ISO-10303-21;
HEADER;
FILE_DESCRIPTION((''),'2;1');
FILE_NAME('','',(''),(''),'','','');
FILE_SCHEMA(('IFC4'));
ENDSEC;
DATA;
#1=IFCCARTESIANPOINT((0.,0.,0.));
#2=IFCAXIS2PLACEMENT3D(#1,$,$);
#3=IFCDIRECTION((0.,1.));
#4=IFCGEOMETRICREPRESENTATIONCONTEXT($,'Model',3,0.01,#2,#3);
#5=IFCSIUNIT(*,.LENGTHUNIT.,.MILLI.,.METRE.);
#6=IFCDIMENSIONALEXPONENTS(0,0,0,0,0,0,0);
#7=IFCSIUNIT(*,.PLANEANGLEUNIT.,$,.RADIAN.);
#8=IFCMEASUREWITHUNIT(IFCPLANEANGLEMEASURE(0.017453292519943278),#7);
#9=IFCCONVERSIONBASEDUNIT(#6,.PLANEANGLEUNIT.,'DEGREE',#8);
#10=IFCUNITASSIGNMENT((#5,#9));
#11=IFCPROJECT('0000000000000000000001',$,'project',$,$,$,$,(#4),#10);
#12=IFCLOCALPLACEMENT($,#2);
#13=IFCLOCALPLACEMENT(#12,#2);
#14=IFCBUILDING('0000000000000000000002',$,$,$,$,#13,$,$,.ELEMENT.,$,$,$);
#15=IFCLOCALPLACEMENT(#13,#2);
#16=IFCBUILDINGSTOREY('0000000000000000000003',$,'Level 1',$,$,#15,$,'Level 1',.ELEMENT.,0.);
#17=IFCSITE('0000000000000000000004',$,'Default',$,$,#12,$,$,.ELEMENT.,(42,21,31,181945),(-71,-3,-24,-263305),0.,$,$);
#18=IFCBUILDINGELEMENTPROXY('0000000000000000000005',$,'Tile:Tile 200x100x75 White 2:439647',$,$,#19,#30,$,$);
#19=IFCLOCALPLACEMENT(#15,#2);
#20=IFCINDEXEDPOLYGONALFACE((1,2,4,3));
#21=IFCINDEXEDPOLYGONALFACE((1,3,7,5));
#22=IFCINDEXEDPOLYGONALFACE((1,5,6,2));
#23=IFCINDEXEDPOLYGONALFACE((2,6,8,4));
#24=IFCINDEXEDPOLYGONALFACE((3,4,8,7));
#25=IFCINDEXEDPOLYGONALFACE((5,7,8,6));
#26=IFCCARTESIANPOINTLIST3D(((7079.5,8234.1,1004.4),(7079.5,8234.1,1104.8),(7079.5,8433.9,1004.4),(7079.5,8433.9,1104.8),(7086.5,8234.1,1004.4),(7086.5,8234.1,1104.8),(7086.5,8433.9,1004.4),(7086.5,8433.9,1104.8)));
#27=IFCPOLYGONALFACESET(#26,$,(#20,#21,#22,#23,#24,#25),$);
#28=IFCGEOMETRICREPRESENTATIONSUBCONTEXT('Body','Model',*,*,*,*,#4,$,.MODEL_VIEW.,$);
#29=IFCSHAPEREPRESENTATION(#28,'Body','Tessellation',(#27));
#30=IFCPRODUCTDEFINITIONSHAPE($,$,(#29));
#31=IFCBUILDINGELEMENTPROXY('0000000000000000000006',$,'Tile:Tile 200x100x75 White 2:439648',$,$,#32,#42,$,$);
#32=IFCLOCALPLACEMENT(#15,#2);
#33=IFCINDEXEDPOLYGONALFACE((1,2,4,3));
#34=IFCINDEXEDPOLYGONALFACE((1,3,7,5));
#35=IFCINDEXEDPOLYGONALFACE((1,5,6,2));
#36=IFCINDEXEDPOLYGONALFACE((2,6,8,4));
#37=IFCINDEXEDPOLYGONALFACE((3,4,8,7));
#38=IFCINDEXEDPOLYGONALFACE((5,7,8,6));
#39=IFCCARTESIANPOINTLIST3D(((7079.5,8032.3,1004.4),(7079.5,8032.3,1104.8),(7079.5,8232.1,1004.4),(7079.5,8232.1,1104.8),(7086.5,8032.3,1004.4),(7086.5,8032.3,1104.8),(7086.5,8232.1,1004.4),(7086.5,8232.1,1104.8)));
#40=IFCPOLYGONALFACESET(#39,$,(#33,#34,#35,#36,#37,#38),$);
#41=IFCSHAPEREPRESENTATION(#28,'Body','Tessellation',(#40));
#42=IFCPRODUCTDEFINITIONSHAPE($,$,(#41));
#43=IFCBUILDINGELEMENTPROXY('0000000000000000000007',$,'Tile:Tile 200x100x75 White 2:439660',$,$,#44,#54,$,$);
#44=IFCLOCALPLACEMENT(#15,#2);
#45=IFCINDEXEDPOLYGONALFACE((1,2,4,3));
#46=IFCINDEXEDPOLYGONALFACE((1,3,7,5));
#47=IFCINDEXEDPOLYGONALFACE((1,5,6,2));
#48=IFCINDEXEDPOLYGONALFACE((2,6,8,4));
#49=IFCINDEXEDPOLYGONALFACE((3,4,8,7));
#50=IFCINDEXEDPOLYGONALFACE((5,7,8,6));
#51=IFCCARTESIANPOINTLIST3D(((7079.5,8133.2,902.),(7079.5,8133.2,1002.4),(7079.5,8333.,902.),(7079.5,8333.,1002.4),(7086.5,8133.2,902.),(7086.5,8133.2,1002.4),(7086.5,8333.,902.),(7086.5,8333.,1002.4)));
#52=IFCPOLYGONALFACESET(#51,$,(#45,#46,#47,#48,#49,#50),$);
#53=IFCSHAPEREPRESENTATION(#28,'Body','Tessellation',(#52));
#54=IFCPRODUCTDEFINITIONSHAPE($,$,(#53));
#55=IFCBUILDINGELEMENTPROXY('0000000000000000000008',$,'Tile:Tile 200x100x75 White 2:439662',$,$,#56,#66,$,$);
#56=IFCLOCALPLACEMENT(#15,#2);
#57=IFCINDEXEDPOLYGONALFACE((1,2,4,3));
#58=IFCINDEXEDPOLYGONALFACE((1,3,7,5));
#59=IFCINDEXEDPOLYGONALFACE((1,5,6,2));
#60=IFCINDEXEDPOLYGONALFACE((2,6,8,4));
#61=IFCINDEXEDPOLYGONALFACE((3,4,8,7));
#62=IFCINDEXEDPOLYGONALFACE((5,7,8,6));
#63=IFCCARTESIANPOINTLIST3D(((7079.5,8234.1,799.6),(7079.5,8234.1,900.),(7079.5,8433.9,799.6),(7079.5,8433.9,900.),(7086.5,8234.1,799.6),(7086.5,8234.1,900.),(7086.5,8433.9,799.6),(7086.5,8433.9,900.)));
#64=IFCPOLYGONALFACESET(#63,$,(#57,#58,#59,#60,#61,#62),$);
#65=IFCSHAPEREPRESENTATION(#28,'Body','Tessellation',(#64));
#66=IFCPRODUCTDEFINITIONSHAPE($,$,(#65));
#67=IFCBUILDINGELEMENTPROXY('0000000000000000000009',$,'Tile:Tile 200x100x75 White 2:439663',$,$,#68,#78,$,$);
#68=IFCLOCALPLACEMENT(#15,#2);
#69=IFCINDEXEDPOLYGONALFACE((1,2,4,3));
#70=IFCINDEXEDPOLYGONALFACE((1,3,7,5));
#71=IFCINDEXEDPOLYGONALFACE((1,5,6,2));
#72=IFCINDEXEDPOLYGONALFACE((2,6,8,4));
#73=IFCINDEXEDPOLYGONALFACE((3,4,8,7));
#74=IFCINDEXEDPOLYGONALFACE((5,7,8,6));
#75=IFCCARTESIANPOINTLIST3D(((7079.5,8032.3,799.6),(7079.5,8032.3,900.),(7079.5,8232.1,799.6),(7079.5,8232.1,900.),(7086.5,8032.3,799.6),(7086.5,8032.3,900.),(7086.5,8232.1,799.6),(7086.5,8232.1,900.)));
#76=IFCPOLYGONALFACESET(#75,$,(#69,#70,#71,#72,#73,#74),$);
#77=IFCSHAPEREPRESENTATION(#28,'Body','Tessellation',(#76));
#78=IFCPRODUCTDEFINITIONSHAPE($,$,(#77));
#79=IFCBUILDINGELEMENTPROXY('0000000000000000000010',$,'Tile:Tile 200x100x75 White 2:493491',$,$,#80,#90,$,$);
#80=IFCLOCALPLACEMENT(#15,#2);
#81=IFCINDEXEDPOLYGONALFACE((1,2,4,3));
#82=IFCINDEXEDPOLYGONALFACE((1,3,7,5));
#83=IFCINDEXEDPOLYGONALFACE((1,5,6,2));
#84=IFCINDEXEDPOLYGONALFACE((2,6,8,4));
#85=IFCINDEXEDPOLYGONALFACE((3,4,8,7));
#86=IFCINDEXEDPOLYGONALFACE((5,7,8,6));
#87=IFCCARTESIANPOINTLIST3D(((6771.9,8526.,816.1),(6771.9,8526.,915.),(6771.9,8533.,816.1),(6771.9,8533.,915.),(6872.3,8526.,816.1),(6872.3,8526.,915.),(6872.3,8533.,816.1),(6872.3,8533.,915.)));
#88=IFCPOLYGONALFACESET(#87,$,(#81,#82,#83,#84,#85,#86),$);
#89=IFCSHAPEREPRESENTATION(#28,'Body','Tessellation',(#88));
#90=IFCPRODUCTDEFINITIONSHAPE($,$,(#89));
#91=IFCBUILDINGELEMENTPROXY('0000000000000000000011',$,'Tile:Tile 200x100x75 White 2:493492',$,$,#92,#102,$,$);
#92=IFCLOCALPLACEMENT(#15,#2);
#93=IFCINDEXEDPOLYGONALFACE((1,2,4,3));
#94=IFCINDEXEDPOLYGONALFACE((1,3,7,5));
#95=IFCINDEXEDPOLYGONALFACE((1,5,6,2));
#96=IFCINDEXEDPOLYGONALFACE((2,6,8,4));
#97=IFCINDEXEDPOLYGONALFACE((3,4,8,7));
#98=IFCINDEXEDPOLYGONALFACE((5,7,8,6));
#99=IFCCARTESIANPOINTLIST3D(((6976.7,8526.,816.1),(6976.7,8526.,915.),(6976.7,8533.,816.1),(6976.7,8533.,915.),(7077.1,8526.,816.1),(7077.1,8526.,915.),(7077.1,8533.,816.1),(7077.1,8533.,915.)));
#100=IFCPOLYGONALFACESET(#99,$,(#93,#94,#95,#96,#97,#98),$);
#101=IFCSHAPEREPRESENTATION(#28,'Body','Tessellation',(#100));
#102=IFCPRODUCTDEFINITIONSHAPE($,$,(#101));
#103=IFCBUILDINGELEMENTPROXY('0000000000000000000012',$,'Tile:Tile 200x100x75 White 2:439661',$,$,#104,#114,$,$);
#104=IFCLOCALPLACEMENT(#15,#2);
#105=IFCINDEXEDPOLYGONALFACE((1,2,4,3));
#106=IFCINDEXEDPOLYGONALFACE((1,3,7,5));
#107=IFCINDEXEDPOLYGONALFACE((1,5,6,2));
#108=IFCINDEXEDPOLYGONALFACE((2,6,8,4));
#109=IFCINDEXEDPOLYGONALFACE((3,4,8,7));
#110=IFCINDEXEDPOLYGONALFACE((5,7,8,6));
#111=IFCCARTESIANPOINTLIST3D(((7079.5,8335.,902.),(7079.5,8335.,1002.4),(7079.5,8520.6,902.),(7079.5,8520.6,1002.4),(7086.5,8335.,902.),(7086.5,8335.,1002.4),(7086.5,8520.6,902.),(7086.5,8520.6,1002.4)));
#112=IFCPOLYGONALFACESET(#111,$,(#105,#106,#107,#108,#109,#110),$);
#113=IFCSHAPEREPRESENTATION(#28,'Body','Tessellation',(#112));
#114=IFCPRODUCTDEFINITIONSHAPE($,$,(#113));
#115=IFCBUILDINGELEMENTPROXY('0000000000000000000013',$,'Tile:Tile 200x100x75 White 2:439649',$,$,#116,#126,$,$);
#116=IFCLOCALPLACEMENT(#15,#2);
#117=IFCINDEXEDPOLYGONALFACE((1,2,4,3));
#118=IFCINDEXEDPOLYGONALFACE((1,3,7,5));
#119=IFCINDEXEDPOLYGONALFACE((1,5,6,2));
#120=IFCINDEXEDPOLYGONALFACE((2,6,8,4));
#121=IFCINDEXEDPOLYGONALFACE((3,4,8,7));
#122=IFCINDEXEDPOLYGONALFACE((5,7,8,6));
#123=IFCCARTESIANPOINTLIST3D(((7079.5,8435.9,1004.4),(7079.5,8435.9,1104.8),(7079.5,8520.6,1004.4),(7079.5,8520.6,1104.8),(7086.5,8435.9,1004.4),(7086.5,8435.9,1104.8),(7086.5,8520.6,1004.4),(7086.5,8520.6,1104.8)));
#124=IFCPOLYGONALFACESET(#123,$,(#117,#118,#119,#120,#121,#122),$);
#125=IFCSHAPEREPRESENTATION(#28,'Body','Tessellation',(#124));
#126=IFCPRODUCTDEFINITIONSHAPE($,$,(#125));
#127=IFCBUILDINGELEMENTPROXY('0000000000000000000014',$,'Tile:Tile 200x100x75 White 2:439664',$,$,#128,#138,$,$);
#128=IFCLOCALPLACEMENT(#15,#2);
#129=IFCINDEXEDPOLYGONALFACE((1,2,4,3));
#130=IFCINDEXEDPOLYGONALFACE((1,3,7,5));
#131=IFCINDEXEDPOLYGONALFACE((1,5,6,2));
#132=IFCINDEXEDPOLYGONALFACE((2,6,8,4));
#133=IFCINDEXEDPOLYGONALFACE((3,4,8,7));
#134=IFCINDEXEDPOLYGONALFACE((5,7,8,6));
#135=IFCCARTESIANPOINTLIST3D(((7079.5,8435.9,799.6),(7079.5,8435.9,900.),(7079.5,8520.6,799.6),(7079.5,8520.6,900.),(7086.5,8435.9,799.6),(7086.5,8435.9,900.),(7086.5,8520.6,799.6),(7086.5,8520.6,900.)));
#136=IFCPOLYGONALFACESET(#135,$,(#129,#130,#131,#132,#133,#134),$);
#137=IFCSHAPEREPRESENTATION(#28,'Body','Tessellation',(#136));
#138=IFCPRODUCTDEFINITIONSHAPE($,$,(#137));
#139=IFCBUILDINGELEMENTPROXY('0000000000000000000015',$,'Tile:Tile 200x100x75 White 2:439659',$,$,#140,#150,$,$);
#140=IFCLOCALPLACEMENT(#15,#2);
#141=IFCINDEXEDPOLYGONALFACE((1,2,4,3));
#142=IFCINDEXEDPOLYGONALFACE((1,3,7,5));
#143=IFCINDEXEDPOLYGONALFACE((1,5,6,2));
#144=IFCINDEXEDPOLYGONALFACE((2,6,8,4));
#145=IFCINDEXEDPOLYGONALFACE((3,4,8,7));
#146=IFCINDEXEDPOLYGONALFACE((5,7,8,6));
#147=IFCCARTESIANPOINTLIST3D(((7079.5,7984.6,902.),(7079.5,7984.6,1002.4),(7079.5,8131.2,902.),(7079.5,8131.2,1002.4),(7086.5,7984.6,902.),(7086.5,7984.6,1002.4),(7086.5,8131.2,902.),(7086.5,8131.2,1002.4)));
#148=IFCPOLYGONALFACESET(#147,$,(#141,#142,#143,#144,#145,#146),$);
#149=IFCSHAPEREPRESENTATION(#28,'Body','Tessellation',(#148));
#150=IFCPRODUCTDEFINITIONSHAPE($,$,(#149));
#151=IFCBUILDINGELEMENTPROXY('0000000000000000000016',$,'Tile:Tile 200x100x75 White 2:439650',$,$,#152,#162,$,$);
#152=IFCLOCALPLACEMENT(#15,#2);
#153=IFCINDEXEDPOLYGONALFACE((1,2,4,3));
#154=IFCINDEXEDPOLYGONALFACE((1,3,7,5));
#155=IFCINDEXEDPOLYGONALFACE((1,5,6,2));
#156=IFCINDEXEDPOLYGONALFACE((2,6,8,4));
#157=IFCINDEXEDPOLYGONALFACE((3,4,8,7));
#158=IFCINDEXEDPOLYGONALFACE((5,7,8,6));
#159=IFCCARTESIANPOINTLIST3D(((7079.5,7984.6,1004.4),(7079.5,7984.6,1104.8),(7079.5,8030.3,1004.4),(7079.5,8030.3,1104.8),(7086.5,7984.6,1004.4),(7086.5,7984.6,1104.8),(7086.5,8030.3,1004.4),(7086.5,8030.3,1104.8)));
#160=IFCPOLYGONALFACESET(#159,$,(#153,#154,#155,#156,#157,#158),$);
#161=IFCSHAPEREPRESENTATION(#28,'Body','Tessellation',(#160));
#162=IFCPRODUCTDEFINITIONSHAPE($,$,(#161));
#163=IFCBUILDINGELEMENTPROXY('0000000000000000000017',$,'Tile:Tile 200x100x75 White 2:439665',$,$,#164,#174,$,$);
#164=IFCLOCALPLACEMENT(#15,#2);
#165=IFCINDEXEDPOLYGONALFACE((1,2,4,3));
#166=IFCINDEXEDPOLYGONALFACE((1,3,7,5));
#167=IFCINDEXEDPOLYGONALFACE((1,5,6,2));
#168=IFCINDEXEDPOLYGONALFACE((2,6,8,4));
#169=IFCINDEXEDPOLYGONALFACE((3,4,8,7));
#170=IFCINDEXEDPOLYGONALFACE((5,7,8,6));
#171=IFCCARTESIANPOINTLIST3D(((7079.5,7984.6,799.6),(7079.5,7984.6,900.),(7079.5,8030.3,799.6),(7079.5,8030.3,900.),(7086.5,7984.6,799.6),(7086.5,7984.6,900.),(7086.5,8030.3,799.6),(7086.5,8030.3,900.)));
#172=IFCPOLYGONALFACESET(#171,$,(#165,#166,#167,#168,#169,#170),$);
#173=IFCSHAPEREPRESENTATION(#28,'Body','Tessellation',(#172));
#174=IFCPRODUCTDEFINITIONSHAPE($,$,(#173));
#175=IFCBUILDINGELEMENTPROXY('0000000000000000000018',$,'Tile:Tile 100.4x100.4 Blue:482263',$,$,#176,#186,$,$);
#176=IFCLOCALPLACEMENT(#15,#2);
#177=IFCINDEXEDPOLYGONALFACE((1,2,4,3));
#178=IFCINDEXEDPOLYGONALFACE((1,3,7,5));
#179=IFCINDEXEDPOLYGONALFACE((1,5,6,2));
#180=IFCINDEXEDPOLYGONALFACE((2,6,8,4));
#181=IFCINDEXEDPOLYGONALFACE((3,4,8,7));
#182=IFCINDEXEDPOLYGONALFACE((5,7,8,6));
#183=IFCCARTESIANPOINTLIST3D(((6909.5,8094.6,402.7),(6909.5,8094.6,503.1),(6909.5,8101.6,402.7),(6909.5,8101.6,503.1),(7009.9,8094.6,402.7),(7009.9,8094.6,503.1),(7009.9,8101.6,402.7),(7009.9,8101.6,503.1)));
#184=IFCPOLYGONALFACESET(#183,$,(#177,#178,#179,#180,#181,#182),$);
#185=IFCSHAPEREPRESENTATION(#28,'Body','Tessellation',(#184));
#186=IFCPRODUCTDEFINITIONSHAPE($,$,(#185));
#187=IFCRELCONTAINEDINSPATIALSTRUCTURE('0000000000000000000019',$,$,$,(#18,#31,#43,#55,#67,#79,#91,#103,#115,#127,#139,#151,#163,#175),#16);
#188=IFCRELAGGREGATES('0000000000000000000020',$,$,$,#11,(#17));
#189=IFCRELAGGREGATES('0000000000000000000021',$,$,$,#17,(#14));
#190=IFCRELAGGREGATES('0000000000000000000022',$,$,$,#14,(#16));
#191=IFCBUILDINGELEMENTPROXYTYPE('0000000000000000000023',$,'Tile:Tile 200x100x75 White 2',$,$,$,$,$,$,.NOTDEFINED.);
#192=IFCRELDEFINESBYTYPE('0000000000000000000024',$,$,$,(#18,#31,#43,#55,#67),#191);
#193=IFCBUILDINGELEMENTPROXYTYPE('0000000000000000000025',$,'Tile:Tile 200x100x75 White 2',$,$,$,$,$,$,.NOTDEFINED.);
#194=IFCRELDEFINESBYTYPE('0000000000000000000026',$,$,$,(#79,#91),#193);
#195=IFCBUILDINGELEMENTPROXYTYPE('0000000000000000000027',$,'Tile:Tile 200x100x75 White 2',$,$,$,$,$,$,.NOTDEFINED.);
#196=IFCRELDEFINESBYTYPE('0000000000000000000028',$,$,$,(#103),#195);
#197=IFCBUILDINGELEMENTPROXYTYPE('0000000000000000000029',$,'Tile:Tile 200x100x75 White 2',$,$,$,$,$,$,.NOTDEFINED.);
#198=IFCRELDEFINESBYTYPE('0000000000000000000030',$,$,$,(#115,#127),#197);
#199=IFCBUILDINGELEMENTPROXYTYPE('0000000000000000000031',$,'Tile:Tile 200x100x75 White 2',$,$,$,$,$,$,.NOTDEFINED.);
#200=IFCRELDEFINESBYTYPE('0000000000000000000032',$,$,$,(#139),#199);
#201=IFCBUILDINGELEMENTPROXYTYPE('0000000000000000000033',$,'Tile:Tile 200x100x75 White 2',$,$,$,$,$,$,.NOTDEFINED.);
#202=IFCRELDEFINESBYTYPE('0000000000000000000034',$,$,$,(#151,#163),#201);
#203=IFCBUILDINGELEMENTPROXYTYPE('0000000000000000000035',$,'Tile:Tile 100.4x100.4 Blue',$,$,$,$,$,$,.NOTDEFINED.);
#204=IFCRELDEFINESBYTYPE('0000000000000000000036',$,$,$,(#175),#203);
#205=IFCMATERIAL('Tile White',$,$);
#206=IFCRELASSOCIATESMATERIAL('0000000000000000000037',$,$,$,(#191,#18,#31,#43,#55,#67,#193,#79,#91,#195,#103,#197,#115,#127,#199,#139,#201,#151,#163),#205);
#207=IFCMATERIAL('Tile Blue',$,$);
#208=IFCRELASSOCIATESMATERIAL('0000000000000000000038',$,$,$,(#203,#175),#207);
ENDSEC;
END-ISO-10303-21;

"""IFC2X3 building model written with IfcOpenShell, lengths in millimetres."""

from ifc_helpers import new_model, entity, si_unit, converted_unit, direction, frame, frame_2d, origin, origin_2d_with_axis, place, context, subcontext, project, spatial, rectangle, extrude, source, transform, mapped, material, type_object, type_shapes, element, save


model = new_model("IFC2X3")

# Units and contexts
model_context = context("Model", 3, precision=0.01, world=origin(), true_north=direction((0.0, 1.0)))
body_context = subcontext(model_context, "Body", "Model", "MODEL_VIEW")
ifc_project = project(units=[si_unit("LENGTHUNIT", "METRE", prefix="MILLI"), converted_unit("PLANEANGLEUNIT", "DEGREE", entity("IfcPlaneAngleMeasure", 0.017453292519943278), si_unit("PLANEANGLEUNIT", "RADIAN"), dimensions=[0, 0, 0, 0, 0, 0, 0])], contexts=[model_context])

# Site, building, storey
site_placement = place(None, origin())
site = spatial("IfcSite", under=ifc_project, at=site_placement, Name="Default", CompositionType="ELEMENT", RefLatitude=(42, 21, 31, 181945), RefLongitude=(-71, -3, -24, -263305), RefElevation=0.0)
building_placement = place(site_placement, origin())
building = spatial("IfcBuilding", under=site, at=building_placement, CompositionType="ELEMENT")
storey_placement = place(building_placement, origin())
storey = spatial("IfcBuildingStorey", under=building, at=storey_placement, Name="Level 1", LongName="Level 1", CompositionType="ELEMENT", Elevation=0.0)

# Building element proxies
ifc_material_1 = material(Name="Tile White")
building_element_proxy_type_1 = type_object("IfcBuildingElementProxyType", Name="Tile:Tile 200x100x75 White 2", PredefinedType="NOTDEFINED", material=ifc_material_1)
shared_shape_1 = source(origin(), body_context, "Body", "SweptSolid", [
    extrude(rectangle(XDim=199.8, YDim=100.4, at=frame_2d((0.0, 0.0), x_axis=(1.0, 0.0))), frame((-50.2, -99.9, 0.0), z_axis=(0.0, 0.0, 1.0), x_axis=(0.0, -1.0, 0.0)), (0.0, 0.0, 1.0), 7.0),
])
type_shapes(building_element_proxy_type_1, [shared_shape_1])
for number, where, z_axis, x_axis, name in (
    (1, (7086.5, 8433.9, 1104.8), (-1.0, 0.0, 0.0), (0.0, 0.0, 1.0), "Tile:Tile 200x100x75 White 2:439647"),
    (2, (7086.5, 8232.1, 1104.8), (-1.0, 0.0, 0.0), (0.0, 0.0, 1.0), "Tile:Tile 200x100x75 White 2:439648"),
    (3, (7086.5, 8333.0, 1002.4), (-1.0, 0.0, 0.0), (0.0, 0.0, 1.0), "Tile:Tile 200x100x75 White 2:439660"),
    (4, (7086.5, 8433.9, 900.0), (-1.0, 0.0, 0.0), (0.0, 0.0, 1.0), "Tile:Tile 200x100x75 White 2:439662"),
    (5, (7086.5, 8232.1, 900.0), (-1.0, 0.0, 0.0), (0.0, 0.0, 1.0), "Tile:Tile 200x100x75 White 2:439663"),
):
    element("IfcBuildingElementProxy", number, at=place(storey_placement, frame(where, z_axis=z_axis, x_axis=x_axis)), inside=storey, type_object=building_element_proxy_type_1, material=ifc_material_1, Name=name, context=body_context, shape_type="MappedRepresentation", body=[
        mapped(shared_shape_1, transform((0.0, 0.0, 0.0), scale=1.0)),
    ])
building_element_proxy_type_2 = type_object("IfcBuildingElementProxyType", Name="Tile:Tile 200x100x75 White 2", PredefinedType="NOTDEFINED", material=ifc_material_1)
shared_shape_2 = source(origin(), body_context, "Body", "SweptSolid", [
    extrude(rectangle(XDim=98.9, YDim=100.4, at=origin_2d_with_axis()), frame((-50.2, -49.5, 0.0), z_axis=(0.0, 0.0, 1.0), x_axis=(0.0, -1.0, 0.0)), (0.0, 0.0, 1.0), 7.0),
])
type_shapes(building_element_proxy_type_2, [shared_shape_2])
for number, where, z_axis, x_axis, name in (
    (6, (6872.3, 8533.0, 915.0), (0.0, -1.0, 0.0), (1.0, 0.0, 0.0), "Tile:Tile 200x100x75 White 2:493491"),
    (7, (7077.1, 8533.0, 915.0), (0.0, -1.0, 0.0), (1.0, 0.0, 0.0), "Tile:Tile 200x100x75 White 2:493492"),
):
    element("IfcBuildingElementProxy", number, at=place(storey_placement, frame(where, z_axis=z_axis, x_axis=x_axis)), inside=storey, type_object=building_element_proxy_type_2, material=ifc_material_1, Name=name, context=body_context, shape_type="MappedRepresentation", body=[
        mapped(shared_shape_2, transform((0.0, 0.0, 0.0), scale=1.0)),
    ])
building_element_proxy_type_3 = type_object("IfcBuildingElementProxyType", Name="Tile:Tile 200x100x75 White 2", PredefinedType="NOTDEFINED", material=ifc_material_1)
shared_shape_3 = source(origin(), body_context, "Body", "SweptSolid", [
    extrude(rectangle(XDim=185.6, YDim=100.4, at=frame_2d((0.0, 0.0), x_axis=(1.0, 0.0))), frame((-50.2, -92.8, 0.0), z_axis=(0.0, 0.0, 1.0), x_axis=(0.0, -1.0, 0.0)), (0.0, 0.0, 1.0), 7.0),
])
type_shapes(building_element_proxy_type_3, [shared_shape_3])
proxy_1_placement = place(storey_placement, frame((7086.5, 8520.6, 1002.4), z_axis=(-1.0, 0.0, 0.0), x_axis=(0.0, 0.0, 1.0)))
element("IfcBuildingElementProxy", 8, at=proxy_1_placement, inside=storey, type_object=building_element_proxy_type_3, material=ifc_material_1, Name="Tile:Tile 200x100x75 White 2:439661", context=body_context, shape_type="MappedRepresentation", body=[
    mapped(shared_shape_3, transform((0.0, 0.0, 0.0), scale=1.0)),
])
building_element_proxy_type_4 = type_object("IfcBuildingElementProxyType", Name="Tile:Tile 200x100x75 White 2", PredefinedType="NOTDEFINED", material=ifc_material_1)
shared_shape_4 = source(origin(), body_context, "Body", "SweptSolid", [
    extrude(rectangle(XDim=84.7, YDim=100.4, at=frame_2d((0.0, 0.0), x_axis=(1.0, 0.0))), frame((-50.2, -42.4, 0.0), z_axis=(0.0, 0.0, 1.0), x_axis=(0.0, -1.0, 0.0)), (0.0, 0.0, 1.0), 7.0),
])
type_shapes(building_element_proxy_type_4, [shared_shape_4])
for number, where, z_axis, x_axis, name in (
    (9, (7086.5, 8520.6, 1104.8), (-1.0, 0.0, 0.0), (0.0, 0.0, 1.0), "Tile:Tile 200x100x75 White 2:439649"),
    (10, (7086.5, 8520.6, 900.0), (-1.0, 0.0, 0.0), (0.0, 0.0, 1.0), "Tile:Tile 200x100x75 White 2:439664"),
):
    element("IfcBuildingElementProxy", number, at=place(storey_placement, frame(where, z_axis=z_axis, x_axis=x_axis)), inside=storey, type_object=building_element_proxy_type_4, material=ifc_material_1, Name=name, context=body_context, shape_type="MappedRepresentation", body=[
        mapped(shared_shape_4, transform((0.0, 0.0, 0.0), scale=1.0)),
    ])
building_element_proxy_type_5 = type_object("IfcBuildingElementProxyType", Name="Tile:Tile 200x100x75 White 2", PredefinedType="NOTDEFINED", material=ifc_material_1)
shared_shape_5 = source(origin(), body_context, "Body", "SweptSolid", [
    extrude(rectangle(XDim=146.6, YDim=100.4, at=origin_2d_with_axis()), frame((-50.2, -73.3, 0.0), z_axis=(0.0, 0.0, 1.0), x_axis=(0.0, -1.0, 0.0)), (0.0, 0.0, 1.0), 7.0),
])
type_shapes(building_element_proxy_type_5, [shared_shape_5])
proxy_2_placement = place(storey_placement, frame((7086.5, 8131.2, 1002.4), z_axis=(-1.0, 0.0, 0.0), x_axis=(0.0, 0.0, 1.0)))
element("IfcBuildingElementProxy", 11, at=proxy_2_placement, inside=storey, type_object=building_element_proxy_type_5, material=ifc_material_1, Name="Tile:Tile 200x100x75 White 2:439659", context=body_context, shape_type="MappedRepresentation", body=[
    mapped(shared_shape_5, transform((0.0, 0.0, 0.0), scale=1.0)),
])
building_element_proxy_type_6 = type_object("IfcBuildingElementProxyType", Name="Tile:Tile 200x100x75 White 2", PredefinedType="NOTDEFINED", material=ifc_material_1)
shared_shape_6 = source(origin(), body_context, "Body", "SweptSolid", [
    extrude(rectangle(XDim=45.7, YDim=100.4, at=frame_2d((0.0, 0.0), x_axis=(1.0, 0.0))), frame((-50.2, -22.9, 0.0), z_axis=(0.0, 0.0, 1.0), x_axis=(0.0, -1.0, 0.0)), (0.0, 0.0, 1.0), 7.0),
])
type_shapes(building_element_proxy_type_6, [shared_shape_6])
for number, where, z_axis, x_axis, name in (
    (12, (7086.5, 8030.3, 1104.8), (-1.0, 0.0, 0.0), (0.0, 0.0, 1.0), "Tile:Tile 200x100x75 White 2:439650"),
    (13, (7086.5, 8030.3, 900.0), (-1.0, 0.0, 0.0), (0.0, 0.0, 1.0), "Tile:Tile 200x100x75 White 2:439665"),
):
    element("IfcBuildingElementProxy", number, at=place(storey_placement, frame(where, z_axis=z_axis, x_axis=x_axis)), inside=storey, type_object=building_element_proxy_type_6, material=ifc_material_1, Name=name, context=body_context, shape_type="MappedRepresentation", body=[
        mapped(shared_shape_6, transform((0.0, 0.0, 0.0), scale=1.0)),
    ])
ifc_material_2 = material(Name="Tile Blue")
building_element_proxy_type_7 = type_object("IfcBuildingElementProxyType", Name="Tile:Tile 100.4x100.4 Blue", PredefinedType="NOTDEFINED", material=ifc_material_2)
shared_shape_7 = source(origin(), body_context, "Body", "SweptSolid", [
    extrude(rectangle(XDim=100.4, YDim=100.4, at=origin_2d_with_axis()), frame((-50.2, -50.2, 0.0), z_axis=(0.0, 0.0, 1.0), x_axis=(0.0, -1.0, 0.0)), (0.0, 0.0, 1.0), 7.0),
])
type_shapes(building_element_proxy_type_7, [shared_shape_7])
proxy_3_placement = place(storey_placement, frame((6909.5, 8101.6, 402.7), z_axis=(0.0, -1.0, 0.0), x_axis=(-1.0, 0.0, 0.0)))
element("IfcBuildingElementProxy", 14, at=proxy_3_placement, inside=storey, type_object=building_element_proxy_type_7, material=ifc_material_2, Name="Tile:Tile 100.4x100.4 Blue:482263", context=body_context, shape_type="MappedRepresentation", body=[
    mapped(shared_shape_7, transform((0.0, 0.0, 0.0), scale=1.0)),
])

save(model, "model.ifc")
